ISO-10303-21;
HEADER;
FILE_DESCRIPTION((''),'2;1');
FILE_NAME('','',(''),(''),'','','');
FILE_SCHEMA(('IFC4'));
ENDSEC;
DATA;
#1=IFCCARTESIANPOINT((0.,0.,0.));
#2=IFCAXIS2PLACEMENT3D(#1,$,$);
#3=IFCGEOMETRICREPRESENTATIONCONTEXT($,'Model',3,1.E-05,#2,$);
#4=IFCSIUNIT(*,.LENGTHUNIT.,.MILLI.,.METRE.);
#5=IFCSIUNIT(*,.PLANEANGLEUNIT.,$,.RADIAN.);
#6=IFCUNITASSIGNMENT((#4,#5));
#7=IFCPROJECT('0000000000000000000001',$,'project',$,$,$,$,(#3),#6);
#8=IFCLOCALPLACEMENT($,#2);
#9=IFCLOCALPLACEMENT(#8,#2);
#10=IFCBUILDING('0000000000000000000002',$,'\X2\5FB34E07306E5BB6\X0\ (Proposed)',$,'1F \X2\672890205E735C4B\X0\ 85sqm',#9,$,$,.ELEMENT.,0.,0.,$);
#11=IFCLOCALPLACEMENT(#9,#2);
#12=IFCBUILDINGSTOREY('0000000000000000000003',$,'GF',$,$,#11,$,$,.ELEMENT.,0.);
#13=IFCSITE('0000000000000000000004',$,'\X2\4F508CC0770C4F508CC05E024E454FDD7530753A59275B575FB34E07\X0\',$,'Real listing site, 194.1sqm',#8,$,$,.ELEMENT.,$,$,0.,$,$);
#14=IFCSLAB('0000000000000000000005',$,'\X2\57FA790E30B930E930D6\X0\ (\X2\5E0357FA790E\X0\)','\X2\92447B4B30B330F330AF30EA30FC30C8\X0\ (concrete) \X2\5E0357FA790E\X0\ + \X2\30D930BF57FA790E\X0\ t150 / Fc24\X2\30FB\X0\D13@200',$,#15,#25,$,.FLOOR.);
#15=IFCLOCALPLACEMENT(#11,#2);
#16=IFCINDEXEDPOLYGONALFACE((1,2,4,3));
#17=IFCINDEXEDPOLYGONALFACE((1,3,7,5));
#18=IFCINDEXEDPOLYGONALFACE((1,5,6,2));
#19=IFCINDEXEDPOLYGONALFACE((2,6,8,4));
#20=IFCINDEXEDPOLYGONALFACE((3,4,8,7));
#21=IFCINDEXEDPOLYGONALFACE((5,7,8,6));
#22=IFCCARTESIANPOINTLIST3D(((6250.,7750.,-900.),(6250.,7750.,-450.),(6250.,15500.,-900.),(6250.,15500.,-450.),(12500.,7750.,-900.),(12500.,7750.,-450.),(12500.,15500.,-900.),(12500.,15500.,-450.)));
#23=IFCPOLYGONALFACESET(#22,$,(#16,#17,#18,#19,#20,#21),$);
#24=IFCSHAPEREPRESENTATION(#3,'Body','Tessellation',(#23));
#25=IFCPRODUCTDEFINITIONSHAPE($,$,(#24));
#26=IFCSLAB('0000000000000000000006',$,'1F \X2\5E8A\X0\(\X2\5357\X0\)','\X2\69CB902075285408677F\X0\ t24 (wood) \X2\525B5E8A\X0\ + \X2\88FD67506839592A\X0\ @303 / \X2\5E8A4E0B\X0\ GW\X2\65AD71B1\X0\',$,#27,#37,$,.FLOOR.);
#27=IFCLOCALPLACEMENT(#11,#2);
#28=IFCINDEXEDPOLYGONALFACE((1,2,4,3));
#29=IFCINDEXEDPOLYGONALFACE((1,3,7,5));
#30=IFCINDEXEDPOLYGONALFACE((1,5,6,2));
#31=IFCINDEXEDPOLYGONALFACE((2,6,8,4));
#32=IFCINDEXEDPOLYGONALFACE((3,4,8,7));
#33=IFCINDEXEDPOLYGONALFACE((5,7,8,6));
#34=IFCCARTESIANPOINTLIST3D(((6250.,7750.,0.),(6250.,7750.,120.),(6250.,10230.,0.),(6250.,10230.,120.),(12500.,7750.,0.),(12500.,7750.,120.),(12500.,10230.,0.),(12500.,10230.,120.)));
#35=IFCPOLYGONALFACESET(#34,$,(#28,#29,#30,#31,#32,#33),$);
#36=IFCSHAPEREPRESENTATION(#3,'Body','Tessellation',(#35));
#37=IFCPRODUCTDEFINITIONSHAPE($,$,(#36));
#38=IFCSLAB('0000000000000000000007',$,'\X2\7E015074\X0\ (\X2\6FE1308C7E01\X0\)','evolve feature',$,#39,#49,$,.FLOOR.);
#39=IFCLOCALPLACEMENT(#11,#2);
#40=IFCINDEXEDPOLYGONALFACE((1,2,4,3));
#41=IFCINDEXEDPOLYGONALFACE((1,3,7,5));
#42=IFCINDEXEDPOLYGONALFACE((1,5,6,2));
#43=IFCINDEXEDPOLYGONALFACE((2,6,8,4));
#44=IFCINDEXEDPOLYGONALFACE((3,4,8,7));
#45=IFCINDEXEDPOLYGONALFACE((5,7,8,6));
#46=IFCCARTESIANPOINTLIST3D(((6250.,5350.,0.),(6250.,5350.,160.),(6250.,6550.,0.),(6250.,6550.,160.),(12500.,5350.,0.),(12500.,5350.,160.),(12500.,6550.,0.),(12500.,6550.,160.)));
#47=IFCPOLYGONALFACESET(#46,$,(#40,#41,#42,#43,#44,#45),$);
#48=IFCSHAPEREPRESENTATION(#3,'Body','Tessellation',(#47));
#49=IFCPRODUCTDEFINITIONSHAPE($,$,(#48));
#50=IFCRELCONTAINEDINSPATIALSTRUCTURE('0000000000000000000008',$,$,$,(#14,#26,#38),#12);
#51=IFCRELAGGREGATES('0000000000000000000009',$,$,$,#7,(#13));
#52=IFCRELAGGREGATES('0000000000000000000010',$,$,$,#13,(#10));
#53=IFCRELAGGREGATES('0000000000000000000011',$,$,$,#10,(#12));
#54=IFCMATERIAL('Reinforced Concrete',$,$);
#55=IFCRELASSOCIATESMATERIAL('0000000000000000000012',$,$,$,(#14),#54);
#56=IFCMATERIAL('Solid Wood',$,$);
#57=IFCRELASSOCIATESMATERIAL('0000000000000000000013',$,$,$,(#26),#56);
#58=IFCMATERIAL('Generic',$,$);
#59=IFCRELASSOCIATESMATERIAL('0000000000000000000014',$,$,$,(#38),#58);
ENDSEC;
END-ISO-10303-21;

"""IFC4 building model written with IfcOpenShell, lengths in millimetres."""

from ifc_helpers import new_model, si_unit, frame, frame_2d, origin, place, context, project, spatial, rectangle, extrude, material, element, save


model = new_model("IFC4")

# Units and contexts
model_context = context("Model", 3, precision=1e-05, world=origin())
ifc_project = project(units=[si_unit("LENGTHUNIT", "METRE", prefix="MILLI"), si_unit("PLANEANGLEUNIT", "RADIAN")], contexts=[model_context])

# Site, building, storey
site_placement = place(None, origin())
site = spatial("IfcSite", under=ifc_project, at=site_placement, Name="佐賀県佐賀市久保田町大字徳万", ObjectType="Real listing site, 194.1sqm", CompositionType="ELEMENT", RefElevation=0.0)
building_placement = place(site_placement, origin())
building = spatial("IfcBuilding", under=site, at=building_placement, Name="徳万の家 (Proposed)", ObjectType="1F 木造平屋 85sqm", CompositionType="ELEMENT", ElevationOfRefHeight=0.0, ElevationOfTerrain=0.0)
storey_placement = place(building_placement, origin())
storey = spatial("IfcBuildingStorey", under=building, at=storey_placement, Name="GF", CompositionType="ELEMENT", Elevation=0.0)

# Slabs
ifc_material_1 = material(Name="Reinforced Concrete")
slab_1_placement = place(storey_placement, frame((3125.0, 3875.0, -450.0)))
element("IfcSlab", 1, at=slab_1_placement, inside=storey, material=ifc_material_1, Name="基礎スラブ (布基礎)", Description="鉄筋コンクリート (concrete) 布基礎 + ベタ基礎 t150 / Fc24・D13@200", PredefinedType="FLOOR", context=model_context, shape_type="SweptSolid", body=[
    extrude(rectangle(XDim=6250.0, YDim=7750.0, at=frame_2d((3125.0, 3875.0))), frame((3125.0, 3875.0, -450.0)), (0.0, 0.0, 1.0), 450.0),
])
ifc_material_2 = material(Name="Solid Wood")
slab_2_placement = place(storey_placement, frame((3125.0, 3875.0, 0.0)))
element("IfcSlab", 2, at=slab_2_placement, inside=storey, material=ifc_material_2, Name="1F 床(南)", Description="構造用合板 t24 (wood) 剛床 + 製材根太 @303 / 床下 GW断熱", PredefinedType="FLOOR", context=model_context, shape_type="SweptSolid", body=[
    extrude(rectangle(XDim=6250.0, YDim=2480.0, at=frame_2d((3125.0, 1240.0))), frame((3125.0, 3875.0, 0.0)), (0.0, 0.0, 1.0), 120.0),
])
ifc_material_3 = material(Name="Generic")
slab_3_placement = place(storey_placement, frame((3125.0, 2675.0, 0.0)))
element("IfcSlab", 3, at=slab_3_placement, inside=storey, material=ifc_material_3, Name="縁側 (濡れ縁)", Description="evolve feature", PredefinedType="FLOOR", context=model_context, shape_type="SweptSolid", body=[
    extrude(rectangle(XDim=6250.0, YDim=1200.0, at=frame_2d((3125.0, 600.0))), frame((3125.0, 2675.0, 0.0)), (0.0, 0.0, 1.0), 160.0),
])

save(model, "model.ifc")
